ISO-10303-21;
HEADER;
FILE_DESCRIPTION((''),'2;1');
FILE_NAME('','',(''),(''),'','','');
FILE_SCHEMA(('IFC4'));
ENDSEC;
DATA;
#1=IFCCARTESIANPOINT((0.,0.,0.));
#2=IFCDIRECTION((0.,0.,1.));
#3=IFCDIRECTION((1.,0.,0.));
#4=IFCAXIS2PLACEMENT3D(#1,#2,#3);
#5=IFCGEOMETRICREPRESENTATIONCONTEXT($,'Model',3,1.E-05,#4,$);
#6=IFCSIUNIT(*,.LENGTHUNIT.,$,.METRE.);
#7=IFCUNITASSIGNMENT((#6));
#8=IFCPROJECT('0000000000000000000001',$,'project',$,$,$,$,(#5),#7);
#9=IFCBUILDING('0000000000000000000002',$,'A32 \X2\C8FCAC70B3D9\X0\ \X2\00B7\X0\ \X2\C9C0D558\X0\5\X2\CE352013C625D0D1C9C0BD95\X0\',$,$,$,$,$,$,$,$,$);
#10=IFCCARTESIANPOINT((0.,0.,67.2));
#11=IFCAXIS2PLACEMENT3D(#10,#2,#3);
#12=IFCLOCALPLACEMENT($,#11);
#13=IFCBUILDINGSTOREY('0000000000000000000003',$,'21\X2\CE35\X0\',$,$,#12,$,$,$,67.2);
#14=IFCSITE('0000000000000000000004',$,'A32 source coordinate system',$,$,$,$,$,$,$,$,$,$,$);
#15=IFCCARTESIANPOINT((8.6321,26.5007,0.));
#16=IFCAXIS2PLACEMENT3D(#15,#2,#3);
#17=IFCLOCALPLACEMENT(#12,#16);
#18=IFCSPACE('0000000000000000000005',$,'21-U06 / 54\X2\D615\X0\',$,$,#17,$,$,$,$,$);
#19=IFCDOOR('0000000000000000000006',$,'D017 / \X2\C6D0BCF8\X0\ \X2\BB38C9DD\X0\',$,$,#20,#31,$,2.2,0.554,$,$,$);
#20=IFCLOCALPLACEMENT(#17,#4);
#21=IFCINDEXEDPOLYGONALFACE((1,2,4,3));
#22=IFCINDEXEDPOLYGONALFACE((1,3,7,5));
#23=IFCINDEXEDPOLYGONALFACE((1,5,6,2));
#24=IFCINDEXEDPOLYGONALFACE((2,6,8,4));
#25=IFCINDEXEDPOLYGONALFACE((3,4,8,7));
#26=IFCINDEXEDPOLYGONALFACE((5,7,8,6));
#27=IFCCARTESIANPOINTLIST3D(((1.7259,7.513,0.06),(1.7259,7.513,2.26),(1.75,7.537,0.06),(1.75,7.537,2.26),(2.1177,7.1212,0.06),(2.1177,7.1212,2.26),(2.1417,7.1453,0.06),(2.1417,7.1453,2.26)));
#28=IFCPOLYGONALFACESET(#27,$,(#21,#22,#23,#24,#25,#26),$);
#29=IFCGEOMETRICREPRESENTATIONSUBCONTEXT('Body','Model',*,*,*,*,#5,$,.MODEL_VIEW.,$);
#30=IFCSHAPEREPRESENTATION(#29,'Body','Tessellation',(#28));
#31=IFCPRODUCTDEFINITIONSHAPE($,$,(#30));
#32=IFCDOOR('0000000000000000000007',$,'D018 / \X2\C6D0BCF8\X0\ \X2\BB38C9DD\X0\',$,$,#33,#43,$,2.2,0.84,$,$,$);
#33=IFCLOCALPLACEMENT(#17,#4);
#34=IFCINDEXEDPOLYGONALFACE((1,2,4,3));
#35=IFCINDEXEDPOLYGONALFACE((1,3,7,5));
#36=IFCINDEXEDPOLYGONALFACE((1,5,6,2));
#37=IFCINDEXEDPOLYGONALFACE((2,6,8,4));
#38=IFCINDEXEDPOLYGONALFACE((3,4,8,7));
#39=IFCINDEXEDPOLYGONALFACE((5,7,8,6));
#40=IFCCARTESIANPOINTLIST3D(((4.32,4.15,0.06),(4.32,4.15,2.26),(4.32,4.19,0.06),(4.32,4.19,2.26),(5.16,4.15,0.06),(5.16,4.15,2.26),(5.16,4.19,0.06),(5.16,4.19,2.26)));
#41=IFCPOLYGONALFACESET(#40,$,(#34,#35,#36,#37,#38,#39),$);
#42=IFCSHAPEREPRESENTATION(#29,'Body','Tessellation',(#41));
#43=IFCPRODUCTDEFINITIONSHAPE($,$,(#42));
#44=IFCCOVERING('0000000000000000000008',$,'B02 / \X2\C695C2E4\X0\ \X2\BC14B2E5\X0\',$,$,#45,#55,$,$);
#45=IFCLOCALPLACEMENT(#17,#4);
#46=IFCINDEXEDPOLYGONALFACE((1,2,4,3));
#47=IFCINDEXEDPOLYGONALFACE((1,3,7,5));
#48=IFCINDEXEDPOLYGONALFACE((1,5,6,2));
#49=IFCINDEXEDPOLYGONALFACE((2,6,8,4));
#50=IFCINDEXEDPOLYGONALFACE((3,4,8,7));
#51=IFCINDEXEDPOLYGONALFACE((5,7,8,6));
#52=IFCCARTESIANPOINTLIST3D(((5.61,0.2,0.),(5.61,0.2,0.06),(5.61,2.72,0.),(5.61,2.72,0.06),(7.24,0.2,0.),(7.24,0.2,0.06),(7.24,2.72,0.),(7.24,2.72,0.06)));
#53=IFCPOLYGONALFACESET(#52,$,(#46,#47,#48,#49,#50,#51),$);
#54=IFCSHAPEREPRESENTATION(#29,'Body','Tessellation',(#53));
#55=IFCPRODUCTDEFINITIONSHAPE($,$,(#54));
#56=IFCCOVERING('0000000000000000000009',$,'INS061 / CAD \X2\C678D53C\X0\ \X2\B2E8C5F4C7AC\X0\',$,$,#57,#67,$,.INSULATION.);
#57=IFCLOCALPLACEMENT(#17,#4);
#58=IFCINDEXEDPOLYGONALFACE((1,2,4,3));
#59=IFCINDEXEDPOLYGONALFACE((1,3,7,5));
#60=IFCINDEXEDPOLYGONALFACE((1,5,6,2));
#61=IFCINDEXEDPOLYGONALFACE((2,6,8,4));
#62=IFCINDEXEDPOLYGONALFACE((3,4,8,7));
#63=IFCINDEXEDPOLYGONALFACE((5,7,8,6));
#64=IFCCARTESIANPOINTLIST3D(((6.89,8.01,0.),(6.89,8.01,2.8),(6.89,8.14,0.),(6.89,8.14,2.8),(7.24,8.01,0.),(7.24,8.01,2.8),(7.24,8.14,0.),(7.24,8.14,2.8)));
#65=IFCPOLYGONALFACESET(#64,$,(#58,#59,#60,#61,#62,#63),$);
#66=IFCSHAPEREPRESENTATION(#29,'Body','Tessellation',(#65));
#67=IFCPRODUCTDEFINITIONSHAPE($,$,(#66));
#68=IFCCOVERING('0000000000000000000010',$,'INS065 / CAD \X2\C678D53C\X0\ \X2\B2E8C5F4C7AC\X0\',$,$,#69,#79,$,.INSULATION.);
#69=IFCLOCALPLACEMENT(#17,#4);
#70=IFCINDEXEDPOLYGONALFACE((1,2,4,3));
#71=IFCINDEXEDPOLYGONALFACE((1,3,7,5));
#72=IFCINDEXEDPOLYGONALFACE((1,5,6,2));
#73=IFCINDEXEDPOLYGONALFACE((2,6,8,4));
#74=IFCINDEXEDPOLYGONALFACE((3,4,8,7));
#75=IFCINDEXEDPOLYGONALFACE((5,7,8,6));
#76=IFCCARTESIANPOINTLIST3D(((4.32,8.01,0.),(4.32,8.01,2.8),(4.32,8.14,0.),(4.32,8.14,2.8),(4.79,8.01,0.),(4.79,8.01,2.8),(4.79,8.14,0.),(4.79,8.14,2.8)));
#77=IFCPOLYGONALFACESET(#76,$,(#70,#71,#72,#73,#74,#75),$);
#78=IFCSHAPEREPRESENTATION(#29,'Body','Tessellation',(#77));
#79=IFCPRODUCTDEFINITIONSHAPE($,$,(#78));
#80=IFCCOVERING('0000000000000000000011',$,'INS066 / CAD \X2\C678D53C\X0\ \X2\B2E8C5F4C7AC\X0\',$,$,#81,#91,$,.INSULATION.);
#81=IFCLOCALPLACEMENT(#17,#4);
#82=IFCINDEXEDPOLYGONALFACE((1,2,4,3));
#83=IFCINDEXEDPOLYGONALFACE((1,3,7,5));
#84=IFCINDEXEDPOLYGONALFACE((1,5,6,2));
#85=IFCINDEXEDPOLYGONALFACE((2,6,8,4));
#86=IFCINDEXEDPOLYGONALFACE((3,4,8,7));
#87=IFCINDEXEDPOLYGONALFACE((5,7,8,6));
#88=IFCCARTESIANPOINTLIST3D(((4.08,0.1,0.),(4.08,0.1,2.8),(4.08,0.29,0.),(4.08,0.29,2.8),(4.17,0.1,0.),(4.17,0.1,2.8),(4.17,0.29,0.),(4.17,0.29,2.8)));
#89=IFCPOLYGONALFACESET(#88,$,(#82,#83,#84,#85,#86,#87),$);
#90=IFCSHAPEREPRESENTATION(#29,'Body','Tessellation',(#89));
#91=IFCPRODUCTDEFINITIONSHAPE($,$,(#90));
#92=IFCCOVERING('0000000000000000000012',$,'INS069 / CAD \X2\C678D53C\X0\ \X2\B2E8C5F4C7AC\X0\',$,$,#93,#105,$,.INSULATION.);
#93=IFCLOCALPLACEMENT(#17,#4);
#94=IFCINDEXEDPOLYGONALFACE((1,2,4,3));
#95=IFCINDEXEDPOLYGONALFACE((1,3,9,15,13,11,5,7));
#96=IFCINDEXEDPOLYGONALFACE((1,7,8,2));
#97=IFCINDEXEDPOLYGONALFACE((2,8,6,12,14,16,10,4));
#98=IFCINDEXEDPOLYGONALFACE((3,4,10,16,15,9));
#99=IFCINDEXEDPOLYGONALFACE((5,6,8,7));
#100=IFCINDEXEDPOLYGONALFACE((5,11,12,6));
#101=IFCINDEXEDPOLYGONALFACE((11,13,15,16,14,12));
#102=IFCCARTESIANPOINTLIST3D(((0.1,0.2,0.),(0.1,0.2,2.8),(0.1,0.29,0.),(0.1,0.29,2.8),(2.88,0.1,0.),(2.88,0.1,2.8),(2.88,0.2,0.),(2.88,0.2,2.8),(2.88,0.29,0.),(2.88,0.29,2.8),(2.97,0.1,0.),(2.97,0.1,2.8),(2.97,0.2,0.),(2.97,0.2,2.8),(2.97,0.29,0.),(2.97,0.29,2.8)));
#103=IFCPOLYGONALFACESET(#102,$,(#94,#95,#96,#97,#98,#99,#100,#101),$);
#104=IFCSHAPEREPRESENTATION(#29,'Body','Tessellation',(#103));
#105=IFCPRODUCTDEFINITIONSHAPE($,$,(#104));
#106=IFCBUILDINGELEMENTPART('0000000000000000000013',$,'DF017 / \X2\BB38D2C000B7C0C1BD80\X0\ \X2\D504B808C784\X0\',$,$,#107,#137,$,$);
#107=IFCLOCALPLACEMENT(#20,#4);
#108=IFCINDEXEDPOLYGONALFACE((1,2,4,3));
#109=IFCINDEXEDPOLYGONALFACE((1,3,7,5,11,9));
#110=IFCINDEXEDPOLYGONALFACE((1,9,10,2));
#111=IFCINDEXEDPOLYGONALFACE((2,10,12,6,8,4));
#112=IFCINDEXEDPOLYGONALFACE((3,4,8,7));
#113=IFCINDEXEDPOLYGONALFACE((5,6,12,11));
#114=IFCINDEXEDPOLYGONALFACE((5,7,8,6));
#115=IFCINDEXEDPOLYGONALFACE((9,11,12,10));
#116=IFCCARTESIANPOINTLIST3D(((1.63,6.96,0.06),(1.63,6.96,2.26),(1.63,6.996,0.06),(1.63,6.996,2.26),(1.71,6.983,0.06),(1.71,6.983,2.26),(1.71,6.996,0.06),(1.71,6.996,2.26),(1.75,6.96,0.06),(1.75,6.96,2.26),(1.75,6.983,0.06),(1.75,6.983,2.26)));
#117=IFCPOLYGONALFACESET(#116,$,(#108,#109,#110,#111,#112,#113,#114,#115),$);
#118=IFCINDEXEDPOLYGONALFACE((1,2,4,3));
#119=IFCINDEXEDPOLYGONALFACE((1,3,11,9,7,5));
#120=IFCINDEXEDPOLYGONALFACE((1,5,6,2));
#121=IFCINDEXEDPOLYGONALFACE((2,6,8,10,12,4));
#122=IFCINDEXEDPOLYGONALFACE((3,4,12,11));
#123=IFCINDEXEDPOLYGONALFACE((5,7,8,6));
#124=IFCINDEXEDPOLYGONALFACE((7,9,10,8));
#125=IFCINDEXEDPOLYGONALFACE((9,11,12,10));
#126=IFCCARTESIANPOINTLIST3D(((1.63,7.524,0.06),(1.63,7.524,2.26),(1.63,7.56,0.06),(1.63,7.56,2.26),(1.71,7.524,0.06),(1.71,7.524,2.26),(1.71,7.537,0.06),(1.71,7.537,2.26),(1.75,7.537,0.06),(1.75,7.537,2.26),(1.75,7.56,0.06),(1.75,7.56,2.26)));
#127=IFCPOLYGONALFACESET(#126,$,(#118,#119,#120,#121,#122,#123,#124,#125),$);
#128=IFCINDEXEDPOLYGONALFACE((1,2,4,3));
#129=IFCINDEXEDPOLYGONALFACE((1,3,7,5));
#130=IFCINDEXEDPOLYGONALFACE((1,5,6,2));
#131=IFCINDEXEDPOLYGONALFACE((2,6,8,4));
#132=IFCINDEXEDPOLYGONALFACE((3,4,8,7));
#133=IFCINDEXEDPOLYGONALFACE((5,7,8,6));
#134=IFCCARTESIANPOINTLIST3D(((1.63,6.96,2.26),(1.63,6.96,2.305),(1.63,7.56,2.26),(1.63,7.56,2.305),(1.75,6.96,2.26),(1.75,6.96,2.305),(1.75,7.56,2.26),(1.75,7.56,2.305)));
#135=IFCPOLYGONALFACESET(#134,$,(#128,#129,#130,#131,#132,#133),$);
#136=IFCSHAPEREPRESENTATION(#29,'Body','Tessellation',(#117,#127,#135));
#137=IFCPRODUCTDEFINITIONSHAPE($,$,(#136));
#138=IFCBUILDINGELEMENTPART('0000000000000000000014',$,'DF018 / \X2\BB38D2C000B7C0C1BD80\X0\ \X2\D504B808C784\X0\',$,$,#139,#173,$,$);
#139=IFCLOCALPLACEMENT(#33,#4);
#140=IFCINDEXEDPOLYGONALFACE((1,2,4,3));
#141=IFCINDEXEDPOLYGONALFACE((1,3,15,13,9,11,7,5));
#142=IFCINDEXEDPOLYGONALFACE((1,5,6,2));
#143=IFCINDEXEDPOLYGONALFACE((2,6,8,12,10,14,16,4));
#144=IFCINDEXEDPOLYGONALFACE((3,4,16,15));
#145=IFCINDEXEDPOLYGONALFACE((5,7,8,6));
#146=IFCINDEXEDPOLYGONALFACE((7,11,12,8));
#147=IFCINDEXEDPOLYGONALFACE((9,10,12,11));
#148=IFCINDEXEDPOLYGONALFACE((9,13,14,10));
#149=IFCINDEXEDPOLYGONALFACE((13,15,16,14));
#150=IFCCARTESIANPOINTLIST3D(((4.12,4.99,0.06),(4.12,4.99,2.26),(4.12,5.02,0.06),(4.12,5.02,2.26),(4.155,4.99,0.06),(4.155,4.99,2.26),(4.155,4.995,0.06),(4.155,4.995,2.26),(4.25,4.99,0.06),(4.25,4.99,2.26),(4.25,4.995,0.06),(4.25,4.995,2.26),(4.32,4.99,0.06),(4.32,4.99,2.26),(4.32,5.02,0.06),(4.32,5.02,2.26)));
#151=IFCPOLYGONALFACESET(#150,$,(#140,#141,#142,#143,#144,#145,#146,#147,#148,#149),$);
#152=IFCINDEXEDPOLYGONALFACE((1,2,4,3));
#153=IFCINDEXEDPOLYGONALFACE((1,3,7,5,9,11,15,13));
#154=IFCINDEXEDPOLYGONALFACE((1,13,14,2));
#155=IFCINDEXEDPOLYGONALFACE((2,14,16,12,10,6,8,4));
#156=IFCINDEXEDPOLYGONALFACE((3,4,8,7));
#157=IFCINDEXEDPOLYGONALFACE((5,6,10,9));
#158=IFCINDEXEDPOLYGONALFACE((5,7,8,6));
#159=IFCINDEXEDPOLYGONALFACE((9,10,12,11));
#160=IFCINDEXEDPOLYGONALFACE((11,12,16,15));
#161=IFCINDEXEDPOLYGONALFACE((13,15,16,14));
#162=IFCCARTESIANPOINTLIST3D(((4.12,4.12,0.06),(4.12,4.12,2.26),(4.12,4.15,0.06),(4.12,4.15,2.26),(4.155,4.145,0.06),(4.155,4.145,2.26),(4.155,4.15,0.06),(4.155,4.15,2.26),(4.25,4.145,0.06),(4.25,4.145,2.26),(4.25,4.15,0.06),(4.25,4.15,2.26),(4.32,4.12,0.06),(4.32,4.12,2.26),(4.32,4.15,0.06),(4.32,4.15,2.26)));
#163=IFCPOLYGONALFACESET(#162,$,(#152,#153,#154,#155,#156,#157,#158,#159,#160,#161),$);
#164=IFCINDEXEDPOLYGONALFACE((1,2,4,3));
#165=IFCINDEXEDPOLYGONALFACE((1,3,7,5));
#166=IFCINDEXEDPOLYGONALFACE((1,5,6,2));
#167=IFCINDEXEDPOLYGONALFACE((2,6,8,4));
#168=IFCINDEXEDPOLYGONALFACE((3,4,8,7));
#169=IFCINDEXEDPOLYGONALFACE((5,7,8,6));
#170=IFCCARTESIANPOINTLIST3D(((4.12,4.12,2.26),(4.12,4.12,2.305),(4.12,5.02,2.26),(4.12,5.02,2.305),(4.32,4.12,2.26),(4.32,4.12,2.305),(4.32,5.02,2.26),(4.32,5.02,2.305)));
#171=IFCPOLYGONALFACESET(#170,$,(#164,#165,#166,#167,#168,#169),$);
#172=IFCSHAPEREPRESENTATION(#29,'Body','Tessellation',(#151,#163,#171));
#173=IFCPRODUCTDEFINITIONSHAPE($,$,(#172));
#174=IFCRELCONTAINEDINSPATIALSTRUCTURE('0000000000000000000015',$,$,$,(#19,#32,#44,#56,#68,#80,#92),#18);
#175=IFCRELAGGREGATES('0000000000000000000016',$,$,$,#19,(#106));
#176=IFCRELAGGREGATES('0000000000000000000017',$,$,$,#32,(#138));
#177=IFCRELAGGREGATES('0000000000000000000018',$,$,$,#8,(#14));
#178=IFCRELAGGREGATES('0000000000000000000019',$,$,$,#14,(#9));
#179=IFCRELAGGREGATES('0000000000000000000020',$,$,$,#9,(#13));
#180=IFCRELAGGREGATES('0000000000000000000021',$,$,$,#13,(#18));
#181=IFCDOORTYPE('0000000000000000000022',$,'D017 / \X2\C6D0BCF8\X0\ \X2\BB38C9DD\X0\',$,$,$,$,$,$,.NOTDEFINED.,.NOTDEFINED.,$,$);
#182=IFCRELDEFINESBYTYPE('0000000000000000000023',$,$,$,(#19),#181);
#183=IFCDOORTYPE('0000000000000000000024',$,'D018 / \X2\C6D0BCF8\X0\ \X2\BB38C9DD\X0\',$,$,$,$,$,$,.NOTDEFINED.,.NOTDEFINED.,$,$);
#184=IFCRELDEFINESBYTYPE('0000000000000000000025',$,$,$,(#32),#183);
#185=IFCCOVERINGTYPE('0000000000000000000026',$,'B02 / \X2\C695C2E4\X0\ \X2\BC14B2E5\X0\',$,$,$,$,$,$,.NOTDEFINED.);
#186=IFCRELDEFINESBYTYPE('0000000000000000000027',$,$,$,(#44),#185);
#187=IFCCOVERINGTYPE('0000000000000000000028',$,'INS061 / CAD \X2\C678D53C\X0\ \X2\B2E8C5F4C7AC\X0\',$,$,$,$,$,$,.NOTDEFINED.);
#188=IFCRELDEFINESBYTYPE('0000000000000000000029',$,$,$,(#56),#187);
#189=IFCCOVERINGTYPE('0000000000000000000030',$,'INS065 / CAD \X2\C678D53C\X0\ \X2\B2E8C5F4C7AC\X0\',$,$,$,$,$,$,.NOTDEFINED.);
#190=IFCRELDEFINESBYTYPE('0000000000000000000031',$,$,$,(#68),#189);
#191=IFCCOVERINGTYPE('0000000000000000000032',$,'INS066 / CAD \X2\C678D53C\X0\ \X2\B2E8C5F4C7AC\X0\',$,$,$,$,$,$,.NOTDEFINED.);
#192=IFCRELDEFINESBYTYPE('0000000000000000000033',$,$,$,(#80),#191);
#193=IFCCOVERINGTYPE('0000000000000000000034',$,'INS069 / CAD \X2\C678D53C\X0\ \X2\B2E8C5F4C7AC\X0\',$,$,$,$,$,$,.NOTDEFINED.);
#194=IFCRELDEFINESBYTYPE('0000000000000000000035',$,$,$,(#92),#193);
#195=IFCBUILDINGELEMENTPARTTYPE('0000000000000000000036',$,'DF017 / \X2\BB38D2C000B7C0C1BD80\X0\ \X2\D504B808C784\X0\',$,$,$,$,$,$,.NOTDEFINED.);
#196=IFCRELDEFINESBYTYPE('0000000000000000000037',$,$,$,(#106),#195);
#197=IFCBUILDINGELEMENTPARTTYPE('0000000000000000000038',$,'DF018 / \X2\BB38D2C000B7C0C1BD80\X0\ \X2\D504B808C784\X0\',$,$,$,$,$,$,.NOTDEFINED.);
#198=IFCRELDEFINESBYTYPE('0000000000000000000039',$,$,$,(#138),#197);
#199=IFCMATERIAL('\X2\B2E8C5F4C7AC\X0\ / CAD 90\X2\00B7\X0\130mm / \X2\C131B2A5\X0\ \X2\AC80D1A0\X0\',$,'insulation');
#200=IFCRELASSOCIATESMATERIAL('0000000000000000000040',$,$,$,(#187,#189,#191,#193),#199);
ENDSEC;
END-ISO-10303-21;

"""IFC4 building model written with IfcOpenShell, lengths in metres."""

from ifc_helpers import new_model, si_unit, frame, origin, origin_with_axes, place, context, subcontext, project, spatial, polyline, outline, extrude, source, transform, mapped, material, type_object, type_shapes, element, aggregate, save


model = new_model("IFC4")

# Units and contexts
model_context = context("Model", 3, precision=1e-05, world=origin_with_axes())
body_context = subcontext(model_context, "Body", "Model", "MODEL_VIEW")
ifc_project = project(units=[si_unit("LENGTHUNIT", "METRE")], contexts=[model_context])

# Site, building, storey, space
storey_placement = place(None, frame((0.0, 0.0, 67.2), z_axis=(0.0, 0.0, 1.0), x_axis=(1.0, 0.0, 0.0)))
space_1_placement = place(storey_placement, frame((8.6321, 26.5007, 0.0), z_axis=(0.0, 0.0, 1.0), x_axis=(1.0, 0.0, 0.0)))
site = spatial("IfcSite", under=ifc_project, Name="A32 source coordinate system")
building = spatial("IfcBuilding", under=site, Name="A32 주거동 · 지하5층–옥탑지붕")
storey = spatial("IfcBuildingStorey", under=building, at=storey_placement, Name="21층", Elevation=67.2)
space_1 = spatial("IfcSpace", under=storey, at=space_1_placement, Name="21-U06 / 54형")

# Doors
door_type_1 = type_object("IfcDoorType", Name="D017 / 원본 문짝", OperationType="NOTDEFINED", PredefinedType="NOTDEFINED")
shared_shape_1 = source(origin(), body_context, "Body", "SweptSolid", [
    extrude(outline(polyline([(1.75, 7.537), (2.1417, 7.1453), (2.1177, 7.1212), (1.7259, 7.513), (1.75, 7.537)])), frame((0.0, 0.0, 0.06)), (0.0, 0.0, 1.0), 2.2),
])
type_shapes(door_type_1, [shared_shape_1])
door_1_placement = place(space_1_placement, origin_with_axes())
door_1 = element("IfcDoor", 1, at=door_1_placement, inside=space_1, type_object=door_type_1, Name="D017 / 원본 문짝", OverallHeight=2.2, OverallWidth=0.554, context=body_context, shape_type="MappedRepresentation", body=[
    mapped(shared_shape_1, transform((0.0, 0.0, 0.0), scale=1.0)),
])
door_type_2 = type_object("IfcDoorType", Name="D018 / 원본 문짝", OperationType="NOTDEFINED", PredefinedType="NOTDEFINED")
shared_shape_2 = source(origin(), body_context, "Body", "SweptSolid", [
    extrude(outline(polyline([(5.16, 4.19), (5.16, 4.15), (4.32, 4.15), (4.32, 4.19), (5.16, 4.19)])), frame((0.0, 0.0, 0.06)), (0.0, 0.0, 1.0), 2.2),
])
type_shapes(door_type_2, [shared_shape_2])
door_2_placement = place(space_1_placement, origin_with_axes())
door_2 = element("IfcDoor", 2, at=door_2_placement, inside=space_1, type_object=door_type_2, Name="D018 / 원본 문짝", OverallHeight=2.2, OverallWidth=0.84, context=body_context, shape_type="MappedRepresentation", body=[
    mapped(shared_shape_2, transform((0.0, 0.0, 0.0), scale=1.0)),
])

# Coverings
covering_type_1 = type_object("IfcCoveringType", Name="B02 / 욕실 바닥", PredefinedType="NOTDEFINED")
shared_shape_3 = source(origin(), body_context, "Body", "SweptSolid", [
    extrude(outline(polyline([(5.61, 2.72), (7.24, 2.72), (7.24, 0.2), (5.61, 0.2), (5.61, 2.72)])), origin(), (0.0, 0.0, 1.0), 0.06),
])
type_shapes(covering_type_1, [shared_shape_3])
covering_1_placement = place(space_1_placement, origin_with_axes())
element("IfcCovering", 3, at=covering_1_placement, inside=space_1, type_object=covering_type_1, Name="B02 / 욕실 바닥", context=body_context, shape_type="MappedRepresentation", body=[
    mapped(shared_shape_3, transform((0.0, 0.0, 0.0), scale=1.0)),
])
ifc_material = material(Name="단열재 / CAD 90·130mm / 성능 검토", Category="insulation")
covering_type_2 = type_object("IfcCoveringType", Name="INS061 / CAD 외피 단열재", PredefinedType="NOTDEFINED", material=ifc_material)
shared_shape_4 = source(origin(), body_context, "Body", "SweptSolid", [
    extrude(outline(polyline([(6.89, 8.01), (6.89, 8.14), (7.24, 8.14), (7.24, 8.01), (6.89, 8.01)])), origin(), (0.0, 0.0, 1.0), 2.8),
])
type_shapes(covering_type_2, [shared_shape_4])
covering_2_placement = place(space_1_placement, origin_with_axes())
element("IfcCovering", 4, at=covering_2_placement, inside=space_1, type_object=covering_type_2, Name="INS061 / CAD 외피 단열재", PredefinedType="INSULATION", context=body_context, shape_type="MappedRepresentation", body=[
    mapped(shared_shape_4, transform((0.0, 0.0, 0.0), scale=1.0)),
])
covering_type_3 = type_object("IfcCoveringType", Name="INS065 / CAD 외피 단열재", PredefinedType="NOTDEFINED", material=ifc_material)
shared_shape_5 = source(origin(), body_context, "Body", "SweptSolid", [
    extrude(outline(polyline([(4.32, 8.01), (4.32, 8.14), (4.79, 8.14), (4.79, 8.01), (4.32, 8.01)])), origin(), (0.0, 0.0, 1.0), 2.8),
])
type_shapes(covering_type_3, [shared_shape_5])
covering_3_placement = place(space_1_placement, origin_with_axes())
element("IfcCovering", 5, at=covering_3_placement, inside=space_1, type_object=covering_type_3, Name="INS065 / CAD 외피 단열재", PredefinedType="INSULATION", context=body_context, shape_type="MappedRepresentation", body=[
    mapped(shared_shape_5, transform((0.0, 0.0, 0.0), scale=1.0)),
])
covering_type_4 = type_object("IfcCoveringType", Name="INS066 / CAD 외피 단열재", PredefinedType="NOTDEFINED", material=ifc_material)
shared_shape_6 = source(origin(), body_context, "Body", "SweptSolid", [
    extrude(outline(polyline([(4.08, 0.29), (4.17, 0.29), (4.17, 0.1), (4.08, 0.1), (4.08, 0.29)])), origin(), (0.0, 0.0, 1.0), 2.8),
])
type_shapes(covering_type_4, [shared_shape_6])
covering_4_placement = place(space_1_placement, origin_with_axes())
element("IfcCovering", 6, at=covering_4_placement, inside=space_1, type_object=covering_type_4, Name="INS066 / CAD 외피 단열재", PredefinedType="INSULATION", context=body_context, shape_type="MappedRepresentation", body=[
    mapped(shared_shape_6, transform((0.0, 0.0, 0.0), scale=1.0)),
])
covering_type_5 = type_object("IfcCoveringType", Name="INS069 / CAD 외피 단열재", PredefinedType="NOTDEFINED", material=ifc_material)
shared_shape_7 = source(origin(), body_context, "Body", "SweptSolid", [
    extrude(outline(polyline([(2.97, 0.1), (2.88, 0.1), (2.88, 0.2), (0.1, 0.2), (0.1, 0.29), (2.88, 0.29), (2.97, 0.29), (2.97, 0.2), (2.97, 0.1)])), origin(), (0.0, 0.0, 1.0), 2.8),
])
type_shapes(covering_type_5, [shared_shape_7])
covering_5_placement = place(space_1_placement, origin_with_axes())
element("IfcCovering", 7, at=covering_5_placement, inside=space_1, type_object=covering_type_5, Name="INS069 / CAD 외피 단열재", PredefinedType="INSULATION", context=body_context, shape_type="MappedRepresentation", body=[
    mapped(shared_shape_7, transform((0.0, 0.0, 0.0), scale=1.0)),
])

# Building element parts
building_element_part_type_1 = type_object("IfcBuildingElementPartType", Name="DF017 / 문틀·상부 프레임", PredefinedType="NOTDEFINED")
shared_shape_8 = source(origin(), body_context, "Body", "SweptSolid", [
    extrude(outline(polyline([(1.63, 6.996), (1.71, 6.996), (1.71, 6.983), (1.75, 6.983), (1.75, 6.96), (1.63, 6.96), (1.63, 6.996)])), frame((0.0, 0.0, 0.06)), (0.0, 0.0, 1.0), 2.2),
    extrude(outline(polyline([(1.75, 7.56), (1.75, 7.537), (1.71, 7.537), (1.71, 7.524), (1.63, 7.524), (1.63, 7.56), (1.75, 7.56)])), frame((0.0, 0.0, 0.06)), (0.0, 0.0, 1.0), 2.2),
    extrude(outline(polyline([(1.63, 6.96), (1.63, 7.56), (1.75, 7.56), (1.75, 6.96), (1.63, 6.96)])), frame((0.0, 0.0, 2.26)), (0.0, 0.0, 1.0), 0.045),
])
type_shapes(building_element_part_type_1, [shared_shape_8])
building_element_part_1_placement = place(door_1_placement, origin_with_axes())
building_element_part_1 = element("IfcBuildingElementPart", 8, at=building_element_part_1_placement, type_object=building_element_part_type_1, Name="DF017 / 문틀·상부 프레임", context=body_context, shape_type="MappedRepresentation", body=[
    mapped(shared_shape_8, transform((0.0, 0.0, 0.0), scale=1.0)),
])
aggregate(door_1, [building_element_part_1])
building_element_part_type_2 = type_object("IfcBuildingElementPartType", Name="DF018 / 문틀·상부 프레임", PredefinedType="NOTDEFINED")
shared_shape_9 = source(origin(), body_context, "Body", "SweptSolid", [
    extrude(outline(polyline([(4.32, 4.99), (4.25, 4.99), (4.25, 4.995), (4.155, 4.995), (4.155, 4.99), (4.12, 4.99), (4.12, 5.02), (4.32, 5.02), (4.32, 4.99)])), frame((0.0, 0.0, 0.06)), (0.0, 0.0, 1.0), 2.2),
    extrude(outline(polyline([(4.12, 4.12), (4.12, 4.15), (4.155, 4.15), (4.155, 4.145), (4.25, 4.145), (4.25, 4.15), (4.32, 4.15), (4.32, 4.12), (4.12, 4.12)])), frame((0.0, 0.0, 0.06)), (0.0, 0.0, 1.0), 2.2),
    extrude(outline(polyline([(4.12, 4.12), (4.12, 5.02), (4.32, 5.02), (4.32, 4.12), (4.12, 4.12)])), frame((0.0, 0.0, 2.26)), (0.0, 0.0, 1.0), 0.045),
])
type_shapes(building_element_part_type_2, [shared_shape_9])
building_element_part_2_placement = place(door_2_placement, origin_with_axes())
building_element_part_2 = element("IfcBuildingElementPart", 9, at=building_element_part_2_placement, type_object=building_element_part_type_2, Name="DF018 / 문틀·상부 프레임", context=body_context, shape_type="MappedRepresentation", body=[
    mapped(shared_shape_9, transform((0.0, 0.0, 0.0), scale=1.0)),
])
aggregate(door_2, [building_element_part_2])

save(model, "model.ifc")
